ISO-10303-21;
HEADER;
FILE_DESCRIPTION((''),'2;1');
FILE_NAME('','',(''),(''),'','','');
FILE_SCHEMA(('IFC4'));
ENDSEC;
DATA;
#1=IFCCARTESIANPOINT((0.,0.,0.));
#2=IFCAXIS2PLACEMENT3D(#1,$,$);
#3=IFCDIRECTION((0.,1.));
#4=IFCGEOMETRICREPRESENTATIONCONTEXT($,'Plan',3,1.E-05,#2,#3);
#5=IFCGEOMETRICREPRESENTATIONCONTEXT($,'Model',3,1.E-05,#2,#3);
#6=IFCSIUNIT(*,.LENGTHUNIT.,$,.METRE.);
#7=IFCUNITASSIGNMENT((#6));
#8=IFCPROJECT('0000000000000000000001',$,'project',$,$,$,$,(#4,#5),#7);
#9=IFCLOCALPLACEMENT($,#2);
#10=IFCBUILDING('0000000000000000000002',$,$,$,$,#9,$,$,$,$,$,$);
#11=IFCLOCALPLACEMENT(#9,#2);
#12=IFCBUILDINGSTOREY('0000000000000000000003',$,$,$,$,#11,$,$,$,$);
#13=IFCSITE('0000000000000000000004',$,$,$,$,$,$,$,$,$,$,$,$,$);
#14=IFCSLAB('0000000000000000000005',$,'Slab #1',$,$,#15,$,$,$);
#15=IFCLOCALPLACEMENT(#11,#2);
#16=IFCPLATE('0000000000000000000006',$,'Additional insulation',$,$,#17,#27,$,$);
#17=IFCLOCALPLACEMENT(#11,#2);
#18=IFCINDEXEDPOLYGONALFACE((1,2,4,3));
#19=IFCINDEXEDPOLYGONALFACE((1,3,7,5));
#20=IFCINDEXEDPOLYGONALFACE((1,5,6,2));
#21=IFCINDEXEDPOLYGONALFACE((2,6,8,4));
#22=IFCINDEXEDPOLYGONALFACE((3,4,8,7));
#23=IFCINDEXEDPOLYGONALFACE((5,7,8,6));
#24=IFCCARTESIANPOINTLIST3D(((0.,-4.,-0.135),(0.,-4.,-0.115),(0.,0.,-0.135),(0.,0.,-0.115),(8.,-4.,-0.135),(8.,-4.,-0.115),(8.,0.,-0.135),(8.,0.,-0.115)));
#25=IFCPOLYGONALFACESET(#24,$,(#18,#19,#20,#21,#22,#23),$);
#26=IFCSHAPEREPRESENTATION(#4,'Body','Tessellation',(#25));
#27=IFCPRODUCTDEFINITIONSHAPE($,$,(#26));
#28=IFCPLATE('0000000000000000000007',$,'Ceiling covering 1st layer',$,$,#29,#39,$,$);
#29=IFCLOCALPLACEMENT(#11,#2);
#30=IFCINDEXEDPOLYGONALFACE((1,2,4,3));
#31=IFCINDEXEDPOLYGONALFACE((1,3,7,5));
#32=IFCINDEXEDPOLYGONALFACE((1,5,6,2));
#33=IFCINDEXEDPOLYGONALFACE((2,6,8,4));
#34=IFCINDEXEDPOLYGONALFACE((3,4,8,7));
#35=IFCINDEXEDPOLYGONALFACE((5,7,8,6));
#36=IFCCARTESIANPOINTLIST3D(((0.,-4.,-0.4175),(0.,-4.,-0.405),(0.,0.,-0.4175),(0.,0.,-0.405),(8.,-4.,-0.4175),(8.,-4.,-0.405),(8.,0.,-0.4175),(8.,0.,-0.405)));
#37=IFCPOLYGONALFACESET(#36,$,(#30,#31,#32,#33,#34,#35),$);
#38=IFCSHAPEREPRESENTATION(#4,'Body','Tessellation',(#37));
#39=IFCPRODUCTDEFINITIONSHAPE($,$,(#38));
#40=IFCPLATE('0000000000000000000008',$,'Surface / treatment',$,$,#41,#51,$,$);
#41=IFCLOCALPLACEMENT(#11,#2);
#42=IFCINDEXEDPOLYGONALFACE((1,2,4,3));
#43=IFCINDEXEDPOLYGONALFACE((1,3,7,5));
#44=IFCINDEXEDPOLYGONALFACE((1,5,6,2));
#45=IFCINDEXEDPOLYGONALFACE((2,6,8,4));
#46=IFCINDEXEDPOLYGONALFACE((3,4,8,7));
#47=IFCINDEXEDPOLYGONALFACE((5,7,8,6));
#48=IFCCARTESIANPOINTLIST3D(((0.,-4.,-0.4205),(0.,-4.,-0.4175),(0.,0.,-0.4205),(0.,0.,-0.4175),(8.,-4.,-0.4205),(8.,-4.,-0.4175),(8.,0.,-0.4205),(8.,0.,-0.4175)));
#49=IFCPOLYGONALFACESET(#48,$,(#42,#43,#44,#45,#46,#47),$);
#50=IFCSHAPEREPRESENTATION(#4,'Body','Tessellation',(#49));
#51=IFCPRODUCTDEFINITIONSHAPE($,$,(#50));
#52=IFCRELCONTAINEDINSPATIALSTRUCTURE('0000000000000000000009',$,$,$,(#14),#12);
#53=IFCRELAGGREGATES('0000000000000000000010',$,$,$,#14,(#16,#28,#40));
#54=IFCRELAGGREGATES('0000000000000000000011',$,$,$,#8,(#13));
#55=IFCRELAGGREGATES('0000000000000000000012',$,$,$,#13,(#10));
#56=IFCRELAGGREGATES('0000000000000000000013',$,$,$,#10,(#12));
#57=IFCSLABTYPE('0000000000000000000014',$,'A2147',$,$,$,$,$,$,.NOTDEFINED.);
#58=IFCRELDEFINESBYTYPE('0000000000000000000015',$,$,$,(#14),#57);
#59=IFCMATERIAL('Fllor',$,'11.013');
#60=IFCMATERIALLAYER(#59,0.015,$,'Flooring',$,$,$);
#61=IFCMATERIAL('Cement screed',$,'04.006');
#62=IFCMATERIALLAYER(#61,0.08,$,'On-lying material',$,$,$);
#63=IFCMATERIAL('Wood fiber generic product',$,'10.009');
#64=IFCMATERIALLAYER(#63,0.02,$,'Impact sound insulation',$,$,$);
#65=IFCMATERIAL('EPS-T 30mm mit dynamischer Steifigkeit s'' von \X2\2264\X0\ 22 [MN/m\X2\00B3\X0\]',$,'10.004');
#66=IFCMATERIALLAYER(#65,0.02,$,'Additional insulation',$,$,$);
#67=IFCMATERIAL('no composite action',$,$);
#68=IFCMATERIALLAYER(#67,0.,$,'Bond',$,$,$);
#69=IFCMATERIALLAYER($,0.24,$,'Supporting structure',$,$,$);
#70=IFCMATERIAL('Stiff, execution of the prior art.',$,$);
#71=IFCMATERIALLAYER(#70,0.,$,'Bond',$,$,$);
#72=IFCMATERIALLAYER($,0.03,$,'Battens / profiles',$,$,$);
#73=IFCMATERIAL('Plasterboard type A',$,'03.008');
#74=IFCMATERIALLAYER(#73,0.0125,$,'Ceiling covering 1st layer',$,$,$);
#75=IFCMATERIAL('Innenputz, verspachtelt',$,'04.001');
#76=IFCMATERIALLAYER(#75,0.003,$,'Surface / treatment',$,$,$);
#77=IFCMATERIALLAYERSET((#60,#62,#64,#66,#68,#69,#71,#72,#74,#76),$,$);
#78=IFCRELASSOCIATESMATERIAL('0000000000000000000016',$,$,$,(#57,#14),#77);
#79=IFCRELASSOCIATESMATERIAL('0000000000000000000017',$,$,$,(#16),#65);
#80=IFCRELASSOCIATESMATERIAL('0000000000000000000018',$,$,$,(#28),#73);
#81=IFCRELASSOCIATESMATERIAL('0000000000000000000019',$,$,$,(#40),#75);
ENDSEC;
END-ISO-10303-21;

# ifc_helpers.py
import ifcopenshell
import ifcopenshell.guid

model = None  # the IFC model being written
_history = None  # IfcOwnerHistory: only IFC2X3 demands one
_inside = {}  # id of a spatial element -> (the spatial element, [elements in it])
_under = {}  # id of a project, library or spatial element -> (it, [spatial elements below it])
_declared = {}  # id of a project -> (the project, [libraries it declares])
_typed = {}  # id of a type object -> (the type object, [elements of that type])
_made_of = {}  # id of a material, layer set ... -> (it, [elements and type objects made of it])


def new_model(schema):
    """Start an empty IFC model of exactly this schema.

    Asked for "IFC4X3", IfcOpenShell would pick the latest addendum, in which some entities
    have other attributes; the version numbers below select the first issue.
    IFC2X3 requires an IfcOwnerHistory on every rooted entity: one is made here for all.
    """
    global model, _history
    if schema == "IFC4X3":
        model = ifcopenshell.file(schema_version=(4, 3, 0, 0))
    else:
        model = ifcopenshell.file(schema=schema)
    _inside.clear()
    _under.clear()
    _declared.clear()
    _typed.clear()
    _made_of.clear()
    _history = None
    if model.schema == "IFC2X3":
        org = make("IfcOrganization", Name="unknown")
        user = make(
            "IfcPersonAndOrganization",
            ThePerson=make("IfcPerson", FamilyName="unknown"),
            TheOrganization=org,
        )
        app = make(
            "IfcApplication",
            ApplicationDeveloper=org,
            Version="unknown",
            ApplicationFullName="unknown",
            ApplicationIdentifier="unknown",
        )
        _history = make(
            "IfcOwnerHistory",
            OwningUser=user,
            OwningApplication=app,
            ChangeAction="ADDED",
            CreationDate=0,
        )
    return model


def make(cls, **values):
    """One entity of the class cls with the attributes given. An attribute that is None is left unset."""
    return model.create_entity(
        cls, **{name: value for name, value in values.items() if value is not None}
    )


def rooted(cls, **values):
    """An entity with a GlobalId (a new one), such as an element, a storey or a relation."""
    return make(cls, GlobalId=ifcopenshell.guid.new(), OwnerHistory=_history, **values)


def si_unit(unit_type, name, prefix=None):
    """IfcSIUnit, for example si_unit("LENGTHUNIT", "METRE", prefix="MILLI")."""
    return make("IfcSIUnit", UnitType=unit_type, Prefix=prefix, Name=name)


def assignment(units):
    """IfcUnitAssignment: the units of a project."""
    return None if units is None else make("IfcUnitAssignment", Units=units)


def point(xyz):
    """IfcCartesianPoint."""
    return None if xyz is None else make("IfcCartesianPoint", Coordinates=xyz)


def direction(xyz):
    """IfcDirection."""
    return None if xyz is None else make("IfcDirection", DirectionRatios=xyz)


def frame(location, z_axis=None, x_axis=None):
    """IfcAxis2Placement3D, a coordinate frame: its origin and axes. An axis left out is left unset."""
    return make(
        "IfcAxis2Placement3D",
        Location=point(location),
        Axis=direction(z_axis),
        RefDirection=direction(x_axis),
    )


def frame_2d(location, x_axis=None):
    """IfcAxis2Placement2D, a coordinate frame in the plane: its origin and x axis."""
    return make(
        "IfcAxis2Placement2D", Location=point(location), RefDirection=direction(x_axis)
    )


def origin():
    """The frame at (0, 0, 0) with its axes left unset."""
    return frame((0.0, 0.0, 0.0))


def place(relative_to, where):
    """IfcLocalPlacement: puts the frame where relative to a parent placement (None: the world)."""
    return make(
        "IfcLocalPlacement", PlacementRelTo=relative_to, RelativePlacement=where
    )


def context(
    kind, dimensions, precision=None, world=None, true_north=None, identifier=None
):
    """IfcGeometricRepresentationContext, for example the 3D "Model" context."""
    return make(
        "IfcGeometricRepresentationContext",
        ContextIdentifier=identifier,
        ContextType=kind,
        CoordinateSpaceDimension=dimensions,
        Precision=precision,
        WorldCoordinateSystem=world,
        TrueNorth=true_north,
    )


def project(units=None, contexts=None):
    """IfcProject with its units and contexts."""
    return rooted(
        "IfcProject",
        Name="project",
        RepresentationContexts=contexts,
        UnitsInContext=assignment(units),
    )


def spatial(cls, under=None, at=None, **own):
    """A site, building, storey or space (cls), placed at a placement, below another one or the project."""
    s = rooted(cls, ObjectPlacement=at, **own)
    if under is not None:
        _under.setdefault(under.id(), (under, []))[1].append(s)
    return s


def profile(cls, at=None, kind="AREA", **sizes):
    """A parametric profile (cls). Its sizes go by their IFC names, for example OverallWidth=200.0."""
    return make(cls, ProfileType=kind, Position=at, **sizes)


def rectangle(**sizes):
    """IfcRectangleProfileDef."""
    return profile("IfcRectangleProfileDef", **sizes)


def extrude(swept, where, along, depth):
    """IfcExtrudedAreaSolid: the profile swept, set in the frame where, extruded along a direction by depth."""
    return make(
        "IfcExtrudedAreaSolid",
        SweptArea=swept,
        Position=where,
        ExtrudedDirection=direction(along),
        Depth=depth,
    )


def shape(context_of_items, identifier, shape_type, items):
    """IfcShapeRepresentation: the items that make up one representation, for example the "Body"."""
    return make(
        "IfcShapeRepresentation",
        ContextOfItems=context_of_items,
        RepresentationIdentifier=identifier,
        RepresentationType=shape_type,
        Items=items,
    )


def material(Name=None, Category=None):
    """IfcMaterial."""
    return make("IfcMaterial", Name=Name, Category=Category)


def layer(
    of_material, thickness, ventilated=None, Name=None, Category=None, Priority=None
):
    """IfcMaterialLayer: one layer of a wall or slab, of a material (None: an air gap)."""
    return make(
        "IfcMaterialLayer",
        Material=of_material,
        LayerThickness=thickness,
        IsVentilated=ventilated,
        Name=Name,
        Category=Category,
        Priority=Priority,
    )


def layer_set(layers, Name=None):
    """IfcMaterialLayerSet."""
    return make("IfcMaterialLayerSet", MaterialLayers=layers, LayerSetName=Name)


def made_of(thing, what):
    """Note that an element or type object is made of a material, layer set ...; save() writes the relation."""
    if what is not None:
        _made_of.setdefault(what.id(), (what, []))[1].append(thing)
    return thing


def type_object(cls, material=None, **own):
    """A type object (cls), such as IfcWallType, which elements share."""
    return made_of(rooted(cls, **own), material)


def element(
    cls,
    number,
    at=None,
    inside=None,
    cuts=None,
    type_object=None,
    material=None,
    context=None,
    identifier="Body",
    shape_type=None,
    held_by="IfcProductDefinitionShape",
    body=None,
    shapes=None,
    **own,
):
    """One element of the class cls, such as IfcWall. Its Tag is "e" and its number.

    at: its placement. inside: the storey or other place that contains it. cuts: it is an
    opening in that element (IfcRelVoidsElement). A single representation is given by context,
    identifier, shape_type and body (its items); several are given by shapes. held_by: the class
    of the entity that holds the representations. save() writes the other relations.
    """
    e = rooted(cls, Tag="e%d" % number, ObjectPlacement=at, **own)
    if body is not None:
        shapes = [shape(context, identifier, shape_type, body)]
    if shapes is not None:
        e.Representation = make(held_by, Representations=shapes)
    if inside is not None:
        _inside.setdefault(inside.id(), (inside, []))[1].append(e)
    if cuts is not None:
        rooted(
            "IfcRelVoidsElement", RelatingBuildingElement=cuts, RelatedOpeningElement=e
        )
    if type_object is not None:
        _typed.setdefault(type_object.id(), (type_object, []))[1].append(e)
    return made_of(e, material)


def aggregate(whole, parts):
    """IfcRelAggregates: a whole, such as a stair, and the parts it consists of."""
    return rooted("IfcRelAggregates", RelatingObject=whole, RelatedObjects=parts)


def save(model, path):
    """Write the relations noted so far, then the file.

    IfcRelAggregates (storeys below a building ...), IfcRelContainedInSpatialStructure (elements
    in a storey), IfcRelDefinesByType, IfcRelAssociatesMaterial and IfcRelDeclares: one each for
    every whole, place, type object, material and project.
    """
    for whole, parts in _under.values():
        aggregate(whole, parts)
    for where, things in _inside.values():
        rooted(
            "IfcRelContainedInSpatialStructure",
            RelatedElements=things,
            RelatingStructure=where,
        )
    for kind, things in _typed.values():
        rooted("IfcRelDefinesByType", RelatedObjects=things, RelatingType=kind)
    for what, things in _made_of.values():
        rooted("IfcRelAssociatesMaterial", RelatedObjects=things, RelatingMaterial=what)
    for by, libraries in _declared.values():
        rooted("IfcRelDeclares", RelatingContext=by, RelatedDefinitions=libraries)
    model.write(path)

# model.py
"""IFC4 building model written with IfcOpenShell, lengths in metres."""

from ifc_helpers import new_model, si_unit, direction, frame, frame_2d, origin, place, context, project, spatial, rectangle, extrude, material, layer, layer_set, type_object, element, aggregate, save


model = new_model("IFC4")

# Units and contexts
plan_context = context("Plan", 3, precision=1e-05, world=origin(), true_north=direction((0.0, 1.0)))
model_context = context("Model", 3, precision=1e-05, world=origin(), true_north=direction((0.0, 1.0)))
ifc_project = project(units=[si_unit("LENGTHUNIT", "METRE")], contexts=[plan_context, model_context])

# Site, building, storey
site = spatial("IfcSite", under=ifc_project)
building_placement = place(None, origin())
building = spatial("IfcBuilding", under=site, at=building_placement)
storey_placement = place(building_placement, origin())
storey = spatial("IfcBuildingStorey", under=building, at=storey_placement)

# Slab, plates
ifc_material_1 = material(Name="Fllor", Category="11.013")
ifc_layer_1 = layer(ifc_material_1, 0.015, Name="Flooring")
ifc_material_2 = material(Name="Cement screed", Category="04.006")
ifc_layer_2 = layer(ifc_material_2, 0.08, Name="On-lying material")
ifc_material_3 = material(Name="Wood fiber generic product", Category="10.009")
ifc_layer_3 = layer(ifc_material_3, 0.02, Name="Impact sound insulation")
ifc_material_4 = material(Name="EPS-T 30mm mit dynamischer Steifigkeit s' von ≤ 22 [MN/m³]", Category="10.004")
ifc_layer_4 = layer(ifc_material_4, 0.02, Name="Additional insulation")
ifc_material_5 = material(Name="no composite action")
ifc_layer_5 = layer(ifc_material_5, 0.0, Name="Bond")
ifc_layer_6 = layer(None, 0.24, Name="Supporting structure")
ifc_material_6 = material(Name="Stiff, execution of the prior art.")
ifc_layer_7 = layer(ifc_material_6, 0.0, Name="Bond")
ifc_layer_8 = layer(None, 0.03, Name="Battens / profiles")
ifc_material_7 = material(Name="Plasterboard type A", Category="03.008")
ifc_layer_9 = layer(ifc_material_7, 0.0125, Name="Ceiling covering 1st layer")
ifc_material_8 = material(Name="Innenputz, verspachtelt", Category="04.001")
ifc_layer_10 = layer(ifc_material_8, 0.003, Name="Surface / treatment")
ifc_layer_set = layer_set([ifc_layer_1, ifc_layer_2, ifc_layer_3, ifc_layer_4, ifc_layer_5, ifc_layer_6, ifc_layer_7, ifc_layer_8, ifc_layer_9, ifc_layer_10])
slab_type = type_object("IfcSlabType", Name="A2147", PredefinedType="NOTDEFINED", material=ifc_layer_set)
slab_placement = place(None, frame((0.0, 0.0, 0.0), z_axis=(0.0, 0.0, -1.0), x_axis=(1.0, 0.0, 0.0)))
slab = element("IfcSlab", 1, at=slab_placement, inside=storey, type_object=slab_type, material=ifc_layer_set, Name="Slab #1")
plate_1_placement = place(slab_placement, origin())
plate_1 = element("IfcPlate", 2, at=plate_1_placement, material=ifc_material_4, Name="Additional insulation", context=plan_context, shape_type="SweptSolid", body=[
    extrude(rectangle(XDim=8.0, YDim=4.0, at=frame_2d((4.0, 2.0), x_axis=(1.0, 0.0))), frame((0.0, 0.0, 0.115), z_axis=(0.0, 0.0, 1.0), x_axis=(1.0, 0.0, 0.0)), (0.0, 0.0, 1.0), 0.02),
])
plate_2_placement = place(slab_placement, origin())
plate_2 = element("IfcPlate", 3, at=plate_2_placement, material=ifc_material_7, Name="Ceiling covering 1st layer", context=plan_context, shape_type="SweptSolid", body=[
    extrude(rectangle(XDim=8.0, YDim=4.0, at=frame_2d((4.0, 2.0), x_axis=(1.0, 0.0))), frame((0.0, 0.0, 0.405), z_axis=(0.0, 0.0, 1.0), x_axis=(1.0, 0.0, 0.0)), (0.0, 0.0, 1.0), 0.0125),
])
plate_3_placement = place(slab_placement, origin())
plate_3 = element("IfcPlate", 4, at=plate_3_placement, material=ifc_material_8, Name="Surface / treatment", context=plan_context, shape_type="SweptSolid", body=[
    extrude(rectangle(XDim=8.0, YDim=4.0, at=frame_2d((4.0, 2.0), x_axis=(1.0, 0.0))), frame((0.0, 0.0, 0.4175), z_axis=(0.0, 0.0, 1.0), x_axis=(1.0, 0.0, 0.0)), (0.0, 0.0, 1.0), 0.003),
])
aggregate(slab, [plate_1, plate_2, plate_3])

save(model, "model.ifc")
